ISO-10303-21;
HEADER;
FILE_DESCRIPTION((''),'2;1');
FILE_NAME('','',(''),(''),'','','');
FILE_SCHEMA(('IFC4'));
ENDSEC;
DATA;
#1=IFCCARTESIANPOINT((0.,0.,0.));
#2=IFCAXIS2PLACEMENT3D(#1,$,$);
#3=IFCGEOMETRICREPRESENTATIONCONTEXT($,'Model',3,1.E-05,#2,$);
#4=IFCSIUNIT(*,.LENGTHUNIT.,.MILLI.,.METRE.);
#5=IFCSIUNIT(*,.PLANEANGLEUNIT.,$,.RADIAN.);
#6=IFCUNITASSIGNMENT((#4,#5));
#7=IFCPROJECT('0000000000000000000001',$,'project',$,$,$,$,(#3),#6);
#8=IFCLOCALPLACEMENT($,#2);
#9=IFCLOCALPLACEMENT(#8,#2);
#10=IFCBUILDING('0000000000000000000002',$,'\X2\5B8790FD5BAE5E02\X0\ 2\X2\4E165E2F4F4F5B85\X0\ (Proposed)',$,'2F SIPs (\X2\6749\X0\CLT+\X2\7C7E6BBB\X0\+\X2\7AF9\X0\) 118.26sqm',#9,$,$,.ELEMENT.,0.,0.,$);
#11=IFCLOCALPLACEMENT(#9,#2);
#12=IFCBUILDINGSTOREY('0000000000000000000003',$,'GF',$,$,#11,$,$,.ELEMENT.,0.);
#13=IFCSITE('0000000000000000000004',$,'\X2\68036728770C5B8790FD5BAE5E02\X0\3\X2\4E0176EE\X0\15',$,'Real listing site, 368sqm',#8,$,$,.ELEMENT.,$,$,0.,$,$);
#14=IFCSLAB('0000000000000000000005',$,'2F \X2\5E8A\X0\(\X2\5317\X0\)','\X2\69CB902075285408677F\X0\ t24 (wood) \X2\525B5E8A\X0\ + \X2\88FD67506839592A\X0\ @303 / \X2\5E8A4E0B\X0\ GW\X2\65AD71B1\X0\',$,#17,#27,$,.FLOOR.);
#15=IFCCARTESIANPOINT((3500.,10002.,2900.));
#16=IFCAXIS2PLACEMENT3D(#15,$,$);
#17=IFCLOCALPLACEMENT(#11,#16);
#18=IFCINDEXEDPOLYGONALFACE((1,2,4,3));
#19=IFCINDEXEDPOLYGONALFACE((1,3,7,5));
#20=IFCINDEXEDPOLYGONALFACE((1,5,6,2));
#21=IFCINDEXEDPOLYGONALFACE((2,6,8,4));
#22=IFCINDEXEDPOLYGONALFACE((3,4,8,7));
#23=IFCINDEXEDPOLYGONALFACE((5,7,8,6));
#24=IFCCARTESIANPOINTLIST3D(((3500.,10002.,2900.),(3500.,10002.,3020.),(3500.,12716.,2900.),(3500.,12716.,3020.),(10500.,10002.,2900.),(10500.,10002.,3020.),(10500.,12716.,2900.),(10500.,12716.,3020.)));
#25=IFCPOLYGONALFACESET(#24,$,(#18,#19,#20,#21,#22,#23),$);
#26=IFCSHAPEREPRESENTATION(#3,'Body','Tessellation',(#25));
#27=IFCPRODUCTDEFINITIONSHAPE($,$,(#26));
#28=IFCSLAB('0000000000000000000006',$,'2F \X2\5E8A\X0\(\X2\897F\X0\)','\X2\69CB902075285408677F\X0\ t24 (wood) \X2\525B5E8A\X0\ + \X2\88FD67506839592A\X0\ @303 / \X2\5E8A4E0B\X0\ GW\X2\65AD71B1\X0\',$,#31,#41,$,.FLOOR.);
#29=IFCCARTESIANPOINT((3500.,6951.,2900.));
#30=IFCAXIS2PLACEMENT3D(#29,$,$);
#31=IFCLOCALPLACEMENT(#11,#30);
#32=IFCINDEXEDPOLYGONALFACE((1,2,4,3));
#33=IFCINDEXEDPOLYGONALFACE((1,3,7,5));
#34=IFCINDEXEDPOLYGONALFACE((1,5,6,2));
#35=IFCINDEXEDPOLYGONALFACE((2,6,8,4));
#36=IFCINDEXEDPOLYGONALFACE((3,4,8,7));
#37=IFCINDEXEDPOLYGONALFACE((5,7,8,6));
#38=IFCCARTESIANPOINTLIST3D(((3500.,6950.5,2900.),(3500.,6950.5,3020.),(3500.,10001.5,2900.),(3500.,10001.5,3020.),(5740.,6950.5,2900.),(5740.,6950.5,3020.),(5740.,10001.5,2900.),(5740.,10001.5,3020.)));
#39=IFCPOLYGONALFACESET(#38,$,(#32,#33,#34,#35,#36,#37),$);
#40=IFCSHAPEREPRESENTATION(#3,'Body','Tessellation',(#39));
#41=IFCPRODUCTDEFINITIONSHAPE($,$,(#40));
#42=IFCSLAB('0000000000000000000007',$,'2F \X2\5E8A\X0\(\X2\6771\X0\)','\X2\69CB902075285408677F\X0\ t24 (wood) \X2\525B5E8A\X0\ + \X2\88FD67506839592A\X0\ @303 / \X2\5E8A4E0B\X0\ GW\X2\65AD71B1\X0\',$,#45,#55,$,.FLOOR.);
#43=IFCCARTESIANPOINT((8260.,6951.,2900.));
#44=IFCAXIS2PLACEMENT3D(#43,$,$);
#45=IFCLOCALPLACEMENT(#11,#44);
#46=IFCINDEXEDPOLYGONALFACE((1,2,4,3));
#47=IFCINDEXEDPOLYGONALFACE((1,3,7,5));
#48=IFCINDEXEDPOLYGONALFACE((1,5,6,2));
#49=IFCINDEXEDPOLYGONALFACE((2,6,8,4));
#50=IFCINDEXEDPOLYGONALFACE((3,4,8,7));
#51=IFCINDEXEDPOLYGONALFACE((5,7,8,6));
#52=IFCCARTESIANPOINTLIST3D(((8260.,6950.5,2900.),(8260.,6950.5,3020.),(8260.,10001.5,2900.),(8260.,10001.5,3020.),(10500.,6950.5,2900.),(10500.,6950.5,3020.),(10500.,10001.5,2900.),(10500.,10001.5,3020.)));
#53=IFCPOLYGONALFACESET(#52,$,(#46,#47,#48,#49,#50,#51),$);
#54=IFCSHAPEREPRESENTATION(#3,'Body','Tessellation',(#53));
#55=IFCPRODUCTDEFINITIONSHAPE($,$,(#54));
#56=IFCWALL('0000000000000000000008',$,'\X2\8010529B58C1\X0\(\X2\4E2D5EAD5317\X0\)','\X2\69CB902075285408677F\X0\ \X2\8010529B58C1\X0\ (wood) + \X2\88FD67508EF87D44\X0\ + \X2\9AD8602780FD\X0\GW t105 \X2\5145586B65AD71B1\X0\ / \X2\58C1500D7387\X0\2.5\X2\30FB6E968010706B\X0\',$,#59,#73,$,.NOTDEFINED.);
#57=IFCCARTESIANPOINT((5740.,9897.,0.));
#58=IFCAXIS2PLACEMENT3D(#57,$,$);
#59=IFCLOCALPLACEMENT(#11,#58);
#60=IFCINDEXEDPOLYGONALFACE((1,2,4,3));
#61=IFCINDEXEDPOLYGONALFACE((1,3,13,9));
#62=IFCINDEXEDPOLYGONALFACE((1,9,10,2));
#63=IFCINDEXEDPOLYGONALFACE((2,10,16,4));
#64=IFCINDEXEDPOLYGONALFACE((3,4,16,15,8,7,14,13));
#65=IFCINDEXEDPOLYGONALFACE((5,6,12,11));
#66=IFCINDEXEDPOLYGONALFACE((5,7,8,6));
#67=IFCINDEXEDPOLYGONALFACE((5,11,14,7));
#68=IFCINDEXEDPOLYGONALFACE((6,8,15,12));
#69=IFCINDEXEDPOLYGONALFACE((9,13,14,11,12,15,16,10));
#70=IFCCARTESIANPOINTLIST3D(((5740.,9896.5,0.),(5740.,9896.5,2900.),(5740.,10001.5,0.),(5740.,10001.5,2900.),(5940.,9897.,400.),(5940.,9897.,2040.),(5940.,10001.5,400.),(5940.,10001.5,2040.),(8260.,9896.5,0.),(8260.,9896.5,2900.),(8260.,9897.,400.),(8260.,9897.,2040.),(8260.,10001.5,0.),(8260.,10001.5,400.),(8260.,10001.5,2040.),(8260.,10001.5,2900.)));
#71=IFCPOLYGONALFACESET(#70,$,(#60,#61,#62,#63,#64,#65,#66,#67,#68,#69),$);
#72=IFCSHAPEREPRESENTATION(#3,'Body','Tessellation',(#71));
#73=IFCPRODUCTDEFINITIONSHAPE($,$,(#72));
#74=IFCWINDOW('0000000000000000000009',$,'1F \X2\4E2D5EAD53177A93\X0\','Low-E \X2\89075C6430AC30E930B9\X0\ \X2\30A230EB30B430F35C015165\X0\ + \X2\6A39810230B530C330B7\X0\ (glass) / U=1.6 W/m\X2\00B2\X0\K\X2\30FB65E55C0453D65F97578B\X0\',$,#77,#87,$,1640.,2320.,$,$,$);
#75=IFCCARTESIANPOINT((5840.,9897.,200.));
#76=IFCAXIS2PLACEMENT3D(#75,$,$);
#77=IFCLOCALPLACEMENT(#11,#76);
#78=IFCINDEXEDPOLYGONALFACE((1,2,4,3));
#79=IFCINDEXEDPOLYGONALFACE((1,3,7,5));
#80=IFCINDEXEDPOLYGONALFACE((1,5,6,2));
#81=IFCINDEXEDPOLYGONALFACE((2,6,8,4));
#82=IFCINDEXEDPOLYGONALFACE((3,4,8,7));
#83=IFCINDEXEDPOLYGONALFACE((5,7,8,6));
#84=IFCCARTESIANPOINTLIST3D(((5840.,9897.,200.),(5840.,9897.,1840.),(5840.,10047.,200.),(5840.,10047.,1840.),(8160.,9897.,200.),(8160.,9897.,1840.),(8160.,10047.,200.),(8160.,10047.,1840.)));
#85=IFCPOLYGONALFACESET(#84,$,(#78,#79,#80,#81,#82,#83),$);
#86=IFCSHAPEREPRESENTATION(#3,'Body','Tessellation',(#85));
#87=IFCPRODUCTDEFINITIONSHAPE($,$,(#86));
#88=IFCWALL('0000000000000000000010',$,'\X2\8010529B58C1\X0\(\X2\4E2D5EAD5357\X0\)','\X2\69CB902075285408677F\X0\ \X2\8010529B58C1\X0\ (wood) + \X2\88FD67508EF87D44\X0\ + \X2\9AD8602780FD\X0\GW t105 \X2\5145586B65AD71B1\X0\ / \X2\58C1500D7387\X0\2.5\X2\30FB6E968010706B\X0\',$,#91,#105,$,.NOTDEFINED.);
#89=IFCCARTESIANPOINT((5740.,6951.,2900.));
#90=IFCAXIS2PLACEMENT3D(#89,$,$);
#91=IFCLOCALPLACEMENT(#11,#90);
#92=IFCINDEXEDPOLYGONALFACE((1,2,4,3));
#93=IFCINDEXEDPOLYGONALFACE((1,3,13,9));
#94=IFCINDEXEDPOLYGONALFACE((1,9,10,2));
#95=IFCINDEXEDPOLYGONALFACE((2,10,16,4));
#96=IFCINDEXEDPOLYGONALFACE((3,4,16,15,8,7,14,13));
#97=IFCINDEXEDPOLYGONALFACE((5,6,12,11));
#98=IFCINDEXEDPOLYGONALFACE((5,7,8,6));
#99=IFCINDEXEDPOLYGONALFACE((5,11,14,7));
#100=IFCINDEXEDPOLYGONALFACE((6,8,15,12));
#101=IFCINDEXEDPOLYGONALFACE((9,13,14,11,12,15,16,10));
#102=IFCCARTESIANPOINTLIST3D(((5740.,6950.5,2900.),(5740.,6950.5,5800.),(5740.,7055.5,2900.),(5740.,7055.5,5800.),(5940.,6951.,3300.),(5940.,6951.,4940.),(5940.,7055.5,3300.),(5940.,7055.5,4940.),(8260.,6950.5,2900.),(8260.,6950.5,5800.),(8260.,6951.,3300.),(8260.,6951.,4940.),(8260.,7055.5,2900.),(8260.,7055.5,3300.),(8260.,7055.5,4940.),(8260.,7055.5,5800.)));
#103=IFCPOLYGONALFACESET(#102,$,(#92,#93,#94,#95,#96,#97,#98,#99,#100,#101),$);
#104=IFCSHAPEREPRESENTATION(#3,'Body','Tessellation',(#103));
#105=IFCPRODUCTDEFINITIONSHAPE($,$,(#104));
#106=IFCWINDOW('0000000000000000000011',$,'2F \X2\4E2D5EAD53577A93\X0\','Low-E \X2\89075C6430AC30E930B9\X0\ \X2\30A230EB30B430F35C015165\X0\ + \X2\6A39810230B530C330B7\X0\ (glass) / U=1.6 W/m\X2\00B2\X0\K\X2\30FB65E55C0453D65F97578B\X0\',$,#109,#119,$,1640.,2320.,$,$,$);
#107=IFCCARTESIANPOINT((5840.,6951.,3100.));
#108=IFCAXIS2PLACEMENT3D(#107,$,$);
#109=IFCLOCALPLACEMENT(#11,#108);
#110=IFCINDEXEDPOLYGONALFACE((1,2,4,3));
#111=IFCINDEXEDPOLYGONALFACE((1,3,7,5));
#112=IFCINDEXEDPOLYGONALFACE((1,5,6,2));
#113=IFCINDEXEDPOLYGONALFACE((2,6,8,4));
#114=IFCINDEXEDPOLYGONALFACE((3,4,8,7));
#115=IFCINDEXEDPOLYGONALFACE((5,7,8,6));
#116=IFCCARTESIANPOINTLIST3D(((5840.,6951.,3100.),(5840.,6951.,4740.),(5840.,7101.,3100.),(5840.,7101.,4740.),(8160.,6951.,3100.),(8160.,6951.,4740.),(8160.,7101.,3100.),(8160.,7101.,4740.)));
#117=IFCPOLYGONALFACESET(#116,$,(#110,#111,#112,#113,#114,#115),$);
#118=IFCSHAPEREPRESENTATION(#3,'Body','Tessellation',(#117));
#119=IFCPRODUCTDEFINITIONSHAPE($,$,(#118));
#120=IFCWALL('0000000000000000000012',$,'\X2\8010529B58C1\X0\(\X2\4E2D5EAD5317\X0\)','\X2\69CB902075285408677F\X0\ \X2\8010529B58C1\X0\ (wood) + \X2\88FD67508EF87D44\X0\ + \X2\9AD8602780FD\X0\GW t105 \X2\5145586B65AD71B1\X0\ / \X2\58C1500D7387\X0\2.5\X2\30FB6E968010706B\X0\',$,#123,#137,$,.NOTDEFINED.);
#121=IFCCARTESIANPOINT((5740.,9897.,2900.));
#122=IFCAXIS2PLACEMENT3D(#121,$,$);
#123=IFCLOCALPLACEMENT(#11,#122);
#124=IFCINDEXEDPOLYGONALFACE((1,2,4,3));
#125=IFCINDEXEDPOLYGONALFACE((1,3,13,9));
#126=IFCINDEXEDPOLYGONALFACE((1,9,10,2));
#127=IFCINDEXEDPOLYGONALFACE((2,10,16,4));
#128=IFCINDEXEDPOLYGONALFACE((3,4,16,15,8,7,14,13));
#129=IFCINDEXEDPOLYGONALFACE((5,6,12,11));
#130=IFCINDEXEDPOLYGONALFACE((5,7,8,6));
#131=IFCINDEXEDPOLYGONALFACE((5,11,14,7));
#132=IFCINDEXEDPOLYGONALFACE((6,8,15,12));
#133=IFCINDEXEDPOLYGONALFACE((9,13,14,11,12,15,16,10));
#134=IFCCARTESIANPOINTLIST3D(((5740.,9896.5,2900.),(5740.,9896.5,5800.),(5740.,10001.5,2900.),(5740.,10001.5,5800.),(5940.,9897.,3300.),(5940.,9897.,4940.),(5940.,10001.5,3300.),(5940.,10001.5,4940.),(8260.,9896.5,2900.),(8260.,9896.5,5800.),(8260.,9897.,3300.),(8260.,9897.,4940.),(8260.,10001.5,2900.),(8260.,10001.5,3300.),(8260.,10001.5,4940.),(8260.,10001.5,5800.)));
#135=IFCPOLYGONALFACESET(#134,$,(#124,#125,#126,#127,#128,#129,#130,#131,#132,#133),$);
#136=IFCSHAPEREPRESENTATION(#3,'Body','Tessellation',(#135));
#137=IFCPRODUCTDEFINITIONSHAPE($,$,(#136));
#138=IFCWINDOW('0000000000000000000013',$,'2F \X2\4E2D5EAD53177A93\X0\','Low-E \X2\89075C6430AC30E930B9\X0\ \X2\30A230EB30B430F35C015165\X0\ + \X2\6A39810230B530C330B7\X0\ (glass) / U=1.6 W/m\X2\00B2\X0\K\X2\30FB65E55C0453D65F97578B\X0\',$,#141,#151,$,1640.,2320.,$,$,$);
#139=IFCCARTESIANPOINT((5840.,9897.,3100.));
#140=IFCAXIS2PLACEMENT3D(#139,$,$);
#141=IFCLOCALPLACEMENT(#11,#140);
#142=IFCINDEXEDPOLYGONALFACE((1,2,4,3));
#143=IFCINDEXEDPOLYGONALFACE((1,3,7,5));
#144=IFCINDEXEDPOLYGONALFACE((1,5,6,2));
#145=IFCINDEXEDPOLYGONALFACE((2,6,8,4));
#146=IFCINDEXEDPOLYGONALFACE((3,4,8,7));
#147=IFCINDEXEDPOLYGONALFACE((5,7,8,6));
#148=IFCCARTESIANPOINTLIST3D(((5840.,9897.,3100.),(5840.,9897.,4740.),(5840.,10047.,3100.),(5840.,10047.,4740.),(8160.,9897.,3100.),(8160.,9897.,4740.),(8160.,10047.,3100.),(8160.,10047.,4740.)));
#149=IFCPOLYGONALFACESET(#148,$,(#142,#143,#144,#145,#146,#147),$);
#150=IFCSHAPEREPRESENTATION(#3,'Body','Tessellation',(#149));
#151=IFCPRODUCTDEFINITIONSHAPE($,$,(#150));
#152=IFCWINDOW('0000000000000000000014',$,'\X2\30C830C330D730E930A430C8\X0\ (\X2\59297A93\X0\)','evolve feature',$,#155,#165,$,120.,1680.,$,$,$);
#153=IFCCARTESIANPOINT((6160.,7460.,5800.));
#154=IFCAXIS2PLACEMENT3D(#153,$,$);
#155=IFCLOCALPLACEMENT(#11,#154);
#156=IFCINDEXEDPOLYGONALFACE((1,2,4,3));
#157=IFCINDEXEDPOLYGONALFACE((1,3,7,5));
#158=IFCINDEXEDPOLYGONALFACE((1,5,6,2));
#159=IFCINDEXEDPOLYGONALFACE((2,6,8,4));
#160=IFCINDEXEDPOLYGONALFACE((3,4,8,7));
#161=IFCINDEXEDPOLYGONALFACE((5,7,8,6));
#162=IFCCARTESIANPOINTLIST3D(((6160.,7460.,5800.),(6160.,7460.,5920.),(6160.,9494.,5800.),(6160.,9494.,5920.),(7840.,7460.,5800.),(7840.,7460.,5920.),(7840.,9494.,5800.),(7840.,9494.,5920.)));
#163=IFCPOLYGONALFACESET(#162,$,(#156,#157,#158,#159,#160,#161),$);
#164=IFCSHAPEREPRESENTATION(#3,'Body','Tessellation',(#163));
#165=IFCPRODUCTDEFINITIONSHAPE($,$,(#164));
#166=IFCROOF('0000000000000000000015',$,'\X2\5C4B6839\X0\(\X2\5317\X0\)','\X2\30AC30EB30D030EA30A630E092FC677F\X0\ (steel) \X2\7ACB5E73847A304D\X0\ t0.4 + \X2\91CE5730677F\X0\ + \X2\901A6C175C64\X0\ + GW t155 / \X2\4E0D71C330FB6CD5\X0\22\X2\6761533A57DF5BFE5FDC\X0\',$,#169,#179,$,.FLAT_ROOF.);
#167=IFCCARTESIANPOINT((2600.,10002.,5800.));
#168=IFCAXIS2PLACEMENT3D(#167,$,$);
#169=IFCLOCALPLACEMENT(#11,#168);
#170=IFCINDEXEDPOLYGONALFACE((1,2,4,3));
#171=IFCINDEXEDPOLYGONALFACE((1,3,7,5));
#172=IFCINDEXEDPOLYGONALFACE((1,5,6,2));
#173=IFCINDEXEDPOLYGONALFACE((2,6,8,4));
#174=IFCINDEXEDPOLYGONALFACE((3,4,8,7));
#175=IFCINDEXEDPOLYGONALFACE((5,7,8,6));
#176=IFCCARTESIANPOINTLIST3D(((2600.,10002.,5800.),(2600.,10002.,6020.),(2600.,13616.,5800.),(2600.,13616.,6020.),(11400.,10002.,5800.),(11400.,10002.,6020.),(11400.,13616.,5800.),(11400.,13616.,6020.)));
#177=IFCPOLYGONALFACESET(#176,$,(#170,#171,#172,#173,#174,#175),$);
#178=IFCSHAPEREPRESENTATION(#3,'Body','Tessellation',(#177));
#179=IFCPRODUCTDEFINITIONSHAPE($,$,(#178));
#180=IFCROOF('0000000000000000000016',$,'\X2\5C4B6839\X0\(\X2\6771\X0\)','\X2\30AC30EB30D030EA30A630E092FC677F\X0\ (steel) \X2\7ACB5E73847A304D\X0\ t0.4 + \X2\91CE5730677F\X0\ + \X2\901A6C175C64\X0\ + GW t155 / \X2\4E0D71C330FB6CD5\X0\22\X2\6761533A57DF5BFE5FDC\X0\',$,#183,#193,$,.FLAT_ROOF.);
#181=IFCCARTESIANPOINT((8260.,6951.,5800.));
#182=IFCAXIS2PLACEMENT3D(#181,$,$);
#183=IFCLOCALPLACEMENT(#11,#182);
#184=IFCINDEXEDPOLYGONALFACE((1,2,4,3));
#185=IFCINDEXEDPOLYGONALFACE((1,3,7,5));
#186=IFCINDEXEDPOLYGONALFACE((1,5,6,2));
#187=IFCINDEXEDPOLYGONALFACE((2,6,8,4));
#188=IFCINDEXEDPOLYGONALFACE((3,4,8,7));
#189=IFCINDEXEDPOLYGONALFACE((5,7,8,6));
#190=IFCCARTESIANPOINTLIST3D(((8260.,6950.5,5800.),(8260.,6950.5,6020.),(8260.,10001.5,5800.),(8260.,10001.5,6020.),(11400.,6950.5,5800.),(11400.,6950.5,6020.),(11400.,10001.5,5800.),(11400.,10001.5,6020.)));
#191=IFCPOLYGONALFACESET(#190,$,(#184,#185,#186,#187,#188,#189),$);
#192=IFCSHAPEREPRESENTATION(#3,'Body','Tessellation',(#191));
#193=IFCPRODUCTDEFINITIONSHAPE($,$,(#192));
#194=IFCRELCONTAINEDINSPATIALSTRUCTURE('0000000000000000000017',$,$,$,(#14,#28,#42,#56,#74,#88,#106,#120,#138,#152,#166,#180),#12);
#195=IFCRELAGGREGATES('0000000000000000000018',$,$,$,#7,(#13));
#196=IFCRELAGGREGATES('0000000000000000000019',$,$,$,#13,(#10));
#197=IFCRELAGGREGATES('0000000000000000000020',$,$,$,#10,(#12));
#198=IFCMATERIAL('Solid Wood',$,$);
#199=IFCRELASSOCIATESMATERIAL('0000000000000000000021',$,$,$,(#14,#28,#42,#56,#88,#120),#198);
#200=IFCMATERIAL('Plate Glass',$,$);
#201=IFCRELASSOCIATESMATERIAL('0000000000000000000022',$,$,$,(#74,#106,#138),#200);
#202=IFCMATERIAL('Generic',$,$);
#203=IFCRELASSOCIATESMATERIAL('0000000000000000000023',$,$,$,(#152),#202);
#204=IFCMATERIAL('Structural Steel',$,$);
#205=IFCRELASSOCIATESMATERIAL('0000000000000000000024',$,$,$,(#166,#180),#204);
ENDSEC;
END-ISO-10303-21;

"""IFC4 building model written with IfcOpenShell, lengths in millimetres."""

from ifc_helpers import new_model, si_unit, frame, frame_2d, origin, place, context, project, spatial, rectangle, extrude, material, element, fill, save


model = new_model("IFC4")

# Units and contexts
model_context = context("Model", 3, precision=1e-05, world=origin())
ifc_project = project(units=[si_unit("LENGTHUNIT", "METRE", prefix="MILLI"), si_unit("PLANEANGLEUNIT", "RADIAN")], contexts=[model_context])

# Site, building, storey
site_placement = place(None, origin())
site = spatial("IfcSite", under=ifc_project, at=site_placement, Name="栃木県宇都宮市3丁目15", ObjectType="Real listing site, 368sqm", CompositionType="ELEMENT", RefElevation=0.0)
building_placement = place(site_placement, origin())
building = spatial("IfcBuilding", under=site, at=building_placement, Name="宇都宮市 2世帯住宅 (Proposed)", ObjectType="2F SIPs (杉CLT+籾殻+竹) 118.26sqm", CompositionType="ELEMENT", ElevationOfRefHeight=0.0, ElevationOfTerrain=0.0)
storey_placement = place(building_placement, origin())
storey = spatial("IfcBuildingStorey", under=building, at=storey_placement, Name="GF", CompositionType="ELEMENT", Elevation=0.0)

# Slabs
ifc_material_1 = material(Name="Solid Wood")
slab_1_placement = place(storey_placement, frame((3500.0, 10002.0, 2900.0)))
element("IfcSlab", 1, at=slab_1_placement, inside=storey, material=ifc_material_1, Name="2F 床(北)", Description="構造用合板 t24 (wood) 剛床 + 製材根太 @303 / 床下 GW断熱", PredefinedType="FLOOR", context=model_context, shape_type="SweptSolid", body=[
    extrude(rectangle(XDim=7000.0, YDim=2714.0, at=frame_2d((3500.0, 1357.0))), frame((3500.0, 10002.0, 2900.0)), (0.0, 0.0, 1.0), 120.0),
])
slab_2_placement = place(storey_placement, frame((3500.0, 6951.0, 2900.0)))
element("IfcSlab", 2, at=slab_2_placement, inside=storey, material=ifc_material_1, Name="2F 床(西)", Description="構造用合板 t24 (wood) 剛床 + 製材根太 @303 / 床下 GW断熱", PredefinedType="FLOOR", context=model_context, shape_type="SweptSolid", body=[
    extrude(rectangle(XDim=2240.0, YDim=3051.0, at=frame_2d((1120.0, 1525.0))), frame((3500.0, 6951.0, 2900.0)), (0.0, 0.0, 1.0), 120.0),
])
slab_3_placement = place(storey_placement, frame((8260.0, 6951.0, 2900.0)))
element("IfcSlab", 3, at=slab_3_placement, inside=storey, material=ifc_material_1, Name="2F 床(東)", Description="構造用合板 t24 (wood) 剛床 + 製材根太 @303 / 床下 GW断熱", PredefinedType="FLOOR", context=model_context, shape_type="SweptSolid", body=[
    extrude(rectangle(XDim=2240.0, YDim=3051.0, at=frame_2d((1120.0, 1525.0))), frame((8260.0, 6951.0, 2900.0)), (0.0, 0.0, 1.0), 120.0),
])

# Wall, opening, window
wall_1_placement = place(storey_placement, frame((5740.0, 9897.0, 0.0)))
wall_1 = element("IfcWall", 4, at=wall_1_placement, inside=storey, material=ifc_material_1, Name="耐力壁(中庭北)", Description="構造用合板 耐力壁 (wood) + 製材軸組 + 高性能GW t105 充填断熱 / 壁倍率2.5・準耐火", PredefinedType="NOTDEFINED", context=model_context, shape_type="SweptSolid", body=[
    extrude(rectangle(XDim=2520.0, YDim=105.0, at=frame_2d((1260.0, 52.0))), frame((5740.0, 9897.0, 0.0)), (0.0, 0.0, 1.0), 2900.0),
])
opening_1_placement = place(storey_placement, frame((5840.0, 9897.0, 200.0)))
opening_1 = element("IfcOpeningElement", 5, at=opening_1_placement, cuts=wall_1, PredefinedType="NOTDEFINED", context=model_context, shape_type="SweptSolid", body=[
    extrude(rectangle(XDim=2320.0, YDim=150.0, at=frame_2d((1160.0, 75.0))), frame((5840.0, 9897.0, 200.0)), (0.0, 0.0, 1.0), 1640.0),
])
ifc_material_2 = material(Name="Plate Glass")
window_1_placement = place(storey_placement, frame((5840.0, 9897.0, 200.0)))
window_1 = element("IfcWindow", 6, at=window_1_placement, inside=storey, material=ifc_material_2, Name="1F 中庭北窓", Description="Low-E 複層ガラス アルゴン封入 + 樹脂サッシ (glass) / U=1.6 W/m²K・日射取得型", OverallHeight=1640.0, OverallWidth=2320.0, context=model_context, shape_type="SweptSolid", body=[
    extrude(rectangle(XDim=2320.0, YDim=150.0, at=frame_2d((1160.0, 75.0))), frame((5840.0, 9897.0, 200.0)), (0.0, 0.0, 1.0), 1640.0),
])
fill(opening_1, window_1)

# Walls, openings, windows
wall_2_placement = place(storey_placement, frame((5740.0, 6951.0, 2900.0)))
wall_2 = element("IfcWall", 7, at=wall_2_placement, inside=storey, material=ifc_material_1, Name="耐力壁(中庭南)", Description="構造用合板 耐力壁 (wood) + 製材軸組 + 高性能GW t105 充填断熱 / 壁倍率2.5・準耐火", PredefinedType="NOTDEFINED", context=model_context, shape_type="SweptSolid", body=[
    extrude(rectangle(XDim=2520.0, YDim=105.0, at=frame_2d((1260.0, 52.0))), frame((5740.0, 6951.0, 2900.0)), (0.0, 0.0, 1.0), 2900.0),
])
opening_2_placement = place(storey_placement, frame((5840.0, 6951.0, 3100.0)))
opening_2 = element("IfcOpeningElement", 8, at=opening_2_placement, cuts=wall_2, PredefinedType="NOTDEFINED", context=model_context, shape_type="SweptSolid", body=[
    extrude(rectangle(XDim=2320.0, YDim=150.0, at=frame_2d((1160.0, 75.0))), frame((5840.0, 6951.0, 3100.0)), (0.0, 0.0, 1.0), 1640.0),
])
window_2_placement = place(storey_placement, frame((5840.0, 6951.0, 3100.0)))
window_2 = element("IfcWindow", 9, at=window_2_placement, inside=storey, material=ifc_material_2, Name="2F 中庭南窓", Description="Low-E 複層ガラス アルゴン封入 + 樹脂サッシ (glass) / U=1.6 W/m²K・日射取得型", OverallHeight=1640.0, OverallWidth=2320.0, context=model_context, shape_type="SweptSolid", body=[
    extrude(rectangle(XDim=2320.0, YDim=150.0, at=frame_2d((1160.0, 75.0))), frame((5840.0, 6951.0, 3100.0)), (0.0, 0.0, 1.0), 1640.0),
])
fill(opening_2, window_2)
wall_3_placement = place(storey_placement, frame((5740.0, 9897.0, 2900.0)))
wall_3 = element("IfcWall", 10, at=wall_3_placement, inside=storey, material=ifc_material_1, Name="耐力壁(中庭北)", Description="構造用合板 耐力壁 (wood) + 製材軸組 + 高性能GW t105 充填断熱 / 壁倍率2.5・準耐火", PredefinedType="NOTDEFINED", context=model_context, shape_type="SweptSolid", body=[
    extrude(rectangle(XDim=2520.0, YDim=105.0, at=frame_2d((1260.0, 52.0))), frame((5740.0, 9897.0, 2900.0)), (0.0, 0.0, 1.0), 2900.0),
])
opening_3_placement = place(storey_placement, frame((5840.0, 9897.0, 3100.0)))
opening_3 = element("IfcOpeningElement", 11, at=opening_3_placement, cuts=wall_3, PredefinedType="NOTDEFINED", context=model_context, shape_type="SweptSolid", body=[
    extrude(rectangle(XDim=2320.0, YDim=150.0, at=frame_2d((1160.0, 75.0))), frame((5840.0, 9897.0, 3100.0)), (0.0, 0.0, 1.0), 1640.0),
])
window_3_placement = place(storey_placement, frame((5840.0, 9897.0, 3100.0)))
window_3 = element("IfcWindow", 12, at=window_3_placement, inside=storey, material=ifc_material_2, Name="2F 中庭北窓", Description="Low-E 複層ガラス アルゴン封入 + 樹脂サッシ (glass) / U=1.6 W/m²K・日射取得型", OverallHeight=1640.0, OverallWidth=2320.0, context=model_context, shape_type="SweptSolid", body=[
    extrude(rectangle(XDim=2320.0, YDim=150.0, at=frame_2d((1160.0, 75.0))), frame((5840.0, 9897.0, 3100.0)), (0.0, 0.0, 1.0), 1640.0),
])
fill(opening_3, window_3)

# Window
ifc_material_3 = material(Name="Generic")
window_4_placement = place(storey_placement, frame((6160.0, 7460.0, 5800.0)))
element("IfcWindow", 13, at=window_4_placement, inside=storey, material=ifc_material_3, Name="トップライト (天窓)", Description="evolve feature", OverallHeight=120.0, OverallWidth=1680.0, context=model_context, shape_type="SweptSolid", body=[
    extrude(rectangle(XDim=1680.0, YDim=2034.0, at=frame_2d((840.0, 1017.0))), frame((6160.0, 7460.0, 5800.0)), (0.0, 0.0, 1.0), 120.0),
])

# Roofs
ifc_material_4 = material(Name="Structural Steel")
roof_1_placement = place(storey_placement, frame((2600.0, 10002.0, 5800.0)))
element("IfcRoof", 14, at=roof_1_placement, inside=storey, material=ifc_material_4, Name="屋根(北)", Description="ガルバリウム鋼板 (steel) 立平葺き t0.4 + 野地板 + 通気層 + GW t155 / 不燃・法22条区域対応", PredefinedType="FLAT_ROOF", context=model_context, shape_type="SweptSolid", body=[
    extrude(rectangle(XDim=8800.0, YDim=3614.0, at=frame_2d((4400.0, 1807.0))), frame((2600.0, 10002.0, 5800.0)), (0.0, 0.0, 1.0), 220.0),
])
roof_2_placement = place(storey_placement, frame((8260.0, 6951.0, 5800.0)))
element("IfcRoof", 15, at=roof_2_placement, inside=storey, material=ifc_material_4, Name="屋根(東)", Description="ガルバリウム鋼板 (steel) 立平葺き t0.4 + 野地板 + 通気層 + GW t155 / 不燃・法22条区域対応", PredefinedType="FLAT_ROOF", context=model_context, shape_type="SweptSolid", body=[
    extrude(rectangle(XDim=3140.0, YDim=3051.0, at=frame_2d((1570.0, 1525.0))), frame((8260.0, 6951.0, 5800.0)), (0.0, 0.0, 1.0), 220.0),
])

save(model, "model.ifc")
